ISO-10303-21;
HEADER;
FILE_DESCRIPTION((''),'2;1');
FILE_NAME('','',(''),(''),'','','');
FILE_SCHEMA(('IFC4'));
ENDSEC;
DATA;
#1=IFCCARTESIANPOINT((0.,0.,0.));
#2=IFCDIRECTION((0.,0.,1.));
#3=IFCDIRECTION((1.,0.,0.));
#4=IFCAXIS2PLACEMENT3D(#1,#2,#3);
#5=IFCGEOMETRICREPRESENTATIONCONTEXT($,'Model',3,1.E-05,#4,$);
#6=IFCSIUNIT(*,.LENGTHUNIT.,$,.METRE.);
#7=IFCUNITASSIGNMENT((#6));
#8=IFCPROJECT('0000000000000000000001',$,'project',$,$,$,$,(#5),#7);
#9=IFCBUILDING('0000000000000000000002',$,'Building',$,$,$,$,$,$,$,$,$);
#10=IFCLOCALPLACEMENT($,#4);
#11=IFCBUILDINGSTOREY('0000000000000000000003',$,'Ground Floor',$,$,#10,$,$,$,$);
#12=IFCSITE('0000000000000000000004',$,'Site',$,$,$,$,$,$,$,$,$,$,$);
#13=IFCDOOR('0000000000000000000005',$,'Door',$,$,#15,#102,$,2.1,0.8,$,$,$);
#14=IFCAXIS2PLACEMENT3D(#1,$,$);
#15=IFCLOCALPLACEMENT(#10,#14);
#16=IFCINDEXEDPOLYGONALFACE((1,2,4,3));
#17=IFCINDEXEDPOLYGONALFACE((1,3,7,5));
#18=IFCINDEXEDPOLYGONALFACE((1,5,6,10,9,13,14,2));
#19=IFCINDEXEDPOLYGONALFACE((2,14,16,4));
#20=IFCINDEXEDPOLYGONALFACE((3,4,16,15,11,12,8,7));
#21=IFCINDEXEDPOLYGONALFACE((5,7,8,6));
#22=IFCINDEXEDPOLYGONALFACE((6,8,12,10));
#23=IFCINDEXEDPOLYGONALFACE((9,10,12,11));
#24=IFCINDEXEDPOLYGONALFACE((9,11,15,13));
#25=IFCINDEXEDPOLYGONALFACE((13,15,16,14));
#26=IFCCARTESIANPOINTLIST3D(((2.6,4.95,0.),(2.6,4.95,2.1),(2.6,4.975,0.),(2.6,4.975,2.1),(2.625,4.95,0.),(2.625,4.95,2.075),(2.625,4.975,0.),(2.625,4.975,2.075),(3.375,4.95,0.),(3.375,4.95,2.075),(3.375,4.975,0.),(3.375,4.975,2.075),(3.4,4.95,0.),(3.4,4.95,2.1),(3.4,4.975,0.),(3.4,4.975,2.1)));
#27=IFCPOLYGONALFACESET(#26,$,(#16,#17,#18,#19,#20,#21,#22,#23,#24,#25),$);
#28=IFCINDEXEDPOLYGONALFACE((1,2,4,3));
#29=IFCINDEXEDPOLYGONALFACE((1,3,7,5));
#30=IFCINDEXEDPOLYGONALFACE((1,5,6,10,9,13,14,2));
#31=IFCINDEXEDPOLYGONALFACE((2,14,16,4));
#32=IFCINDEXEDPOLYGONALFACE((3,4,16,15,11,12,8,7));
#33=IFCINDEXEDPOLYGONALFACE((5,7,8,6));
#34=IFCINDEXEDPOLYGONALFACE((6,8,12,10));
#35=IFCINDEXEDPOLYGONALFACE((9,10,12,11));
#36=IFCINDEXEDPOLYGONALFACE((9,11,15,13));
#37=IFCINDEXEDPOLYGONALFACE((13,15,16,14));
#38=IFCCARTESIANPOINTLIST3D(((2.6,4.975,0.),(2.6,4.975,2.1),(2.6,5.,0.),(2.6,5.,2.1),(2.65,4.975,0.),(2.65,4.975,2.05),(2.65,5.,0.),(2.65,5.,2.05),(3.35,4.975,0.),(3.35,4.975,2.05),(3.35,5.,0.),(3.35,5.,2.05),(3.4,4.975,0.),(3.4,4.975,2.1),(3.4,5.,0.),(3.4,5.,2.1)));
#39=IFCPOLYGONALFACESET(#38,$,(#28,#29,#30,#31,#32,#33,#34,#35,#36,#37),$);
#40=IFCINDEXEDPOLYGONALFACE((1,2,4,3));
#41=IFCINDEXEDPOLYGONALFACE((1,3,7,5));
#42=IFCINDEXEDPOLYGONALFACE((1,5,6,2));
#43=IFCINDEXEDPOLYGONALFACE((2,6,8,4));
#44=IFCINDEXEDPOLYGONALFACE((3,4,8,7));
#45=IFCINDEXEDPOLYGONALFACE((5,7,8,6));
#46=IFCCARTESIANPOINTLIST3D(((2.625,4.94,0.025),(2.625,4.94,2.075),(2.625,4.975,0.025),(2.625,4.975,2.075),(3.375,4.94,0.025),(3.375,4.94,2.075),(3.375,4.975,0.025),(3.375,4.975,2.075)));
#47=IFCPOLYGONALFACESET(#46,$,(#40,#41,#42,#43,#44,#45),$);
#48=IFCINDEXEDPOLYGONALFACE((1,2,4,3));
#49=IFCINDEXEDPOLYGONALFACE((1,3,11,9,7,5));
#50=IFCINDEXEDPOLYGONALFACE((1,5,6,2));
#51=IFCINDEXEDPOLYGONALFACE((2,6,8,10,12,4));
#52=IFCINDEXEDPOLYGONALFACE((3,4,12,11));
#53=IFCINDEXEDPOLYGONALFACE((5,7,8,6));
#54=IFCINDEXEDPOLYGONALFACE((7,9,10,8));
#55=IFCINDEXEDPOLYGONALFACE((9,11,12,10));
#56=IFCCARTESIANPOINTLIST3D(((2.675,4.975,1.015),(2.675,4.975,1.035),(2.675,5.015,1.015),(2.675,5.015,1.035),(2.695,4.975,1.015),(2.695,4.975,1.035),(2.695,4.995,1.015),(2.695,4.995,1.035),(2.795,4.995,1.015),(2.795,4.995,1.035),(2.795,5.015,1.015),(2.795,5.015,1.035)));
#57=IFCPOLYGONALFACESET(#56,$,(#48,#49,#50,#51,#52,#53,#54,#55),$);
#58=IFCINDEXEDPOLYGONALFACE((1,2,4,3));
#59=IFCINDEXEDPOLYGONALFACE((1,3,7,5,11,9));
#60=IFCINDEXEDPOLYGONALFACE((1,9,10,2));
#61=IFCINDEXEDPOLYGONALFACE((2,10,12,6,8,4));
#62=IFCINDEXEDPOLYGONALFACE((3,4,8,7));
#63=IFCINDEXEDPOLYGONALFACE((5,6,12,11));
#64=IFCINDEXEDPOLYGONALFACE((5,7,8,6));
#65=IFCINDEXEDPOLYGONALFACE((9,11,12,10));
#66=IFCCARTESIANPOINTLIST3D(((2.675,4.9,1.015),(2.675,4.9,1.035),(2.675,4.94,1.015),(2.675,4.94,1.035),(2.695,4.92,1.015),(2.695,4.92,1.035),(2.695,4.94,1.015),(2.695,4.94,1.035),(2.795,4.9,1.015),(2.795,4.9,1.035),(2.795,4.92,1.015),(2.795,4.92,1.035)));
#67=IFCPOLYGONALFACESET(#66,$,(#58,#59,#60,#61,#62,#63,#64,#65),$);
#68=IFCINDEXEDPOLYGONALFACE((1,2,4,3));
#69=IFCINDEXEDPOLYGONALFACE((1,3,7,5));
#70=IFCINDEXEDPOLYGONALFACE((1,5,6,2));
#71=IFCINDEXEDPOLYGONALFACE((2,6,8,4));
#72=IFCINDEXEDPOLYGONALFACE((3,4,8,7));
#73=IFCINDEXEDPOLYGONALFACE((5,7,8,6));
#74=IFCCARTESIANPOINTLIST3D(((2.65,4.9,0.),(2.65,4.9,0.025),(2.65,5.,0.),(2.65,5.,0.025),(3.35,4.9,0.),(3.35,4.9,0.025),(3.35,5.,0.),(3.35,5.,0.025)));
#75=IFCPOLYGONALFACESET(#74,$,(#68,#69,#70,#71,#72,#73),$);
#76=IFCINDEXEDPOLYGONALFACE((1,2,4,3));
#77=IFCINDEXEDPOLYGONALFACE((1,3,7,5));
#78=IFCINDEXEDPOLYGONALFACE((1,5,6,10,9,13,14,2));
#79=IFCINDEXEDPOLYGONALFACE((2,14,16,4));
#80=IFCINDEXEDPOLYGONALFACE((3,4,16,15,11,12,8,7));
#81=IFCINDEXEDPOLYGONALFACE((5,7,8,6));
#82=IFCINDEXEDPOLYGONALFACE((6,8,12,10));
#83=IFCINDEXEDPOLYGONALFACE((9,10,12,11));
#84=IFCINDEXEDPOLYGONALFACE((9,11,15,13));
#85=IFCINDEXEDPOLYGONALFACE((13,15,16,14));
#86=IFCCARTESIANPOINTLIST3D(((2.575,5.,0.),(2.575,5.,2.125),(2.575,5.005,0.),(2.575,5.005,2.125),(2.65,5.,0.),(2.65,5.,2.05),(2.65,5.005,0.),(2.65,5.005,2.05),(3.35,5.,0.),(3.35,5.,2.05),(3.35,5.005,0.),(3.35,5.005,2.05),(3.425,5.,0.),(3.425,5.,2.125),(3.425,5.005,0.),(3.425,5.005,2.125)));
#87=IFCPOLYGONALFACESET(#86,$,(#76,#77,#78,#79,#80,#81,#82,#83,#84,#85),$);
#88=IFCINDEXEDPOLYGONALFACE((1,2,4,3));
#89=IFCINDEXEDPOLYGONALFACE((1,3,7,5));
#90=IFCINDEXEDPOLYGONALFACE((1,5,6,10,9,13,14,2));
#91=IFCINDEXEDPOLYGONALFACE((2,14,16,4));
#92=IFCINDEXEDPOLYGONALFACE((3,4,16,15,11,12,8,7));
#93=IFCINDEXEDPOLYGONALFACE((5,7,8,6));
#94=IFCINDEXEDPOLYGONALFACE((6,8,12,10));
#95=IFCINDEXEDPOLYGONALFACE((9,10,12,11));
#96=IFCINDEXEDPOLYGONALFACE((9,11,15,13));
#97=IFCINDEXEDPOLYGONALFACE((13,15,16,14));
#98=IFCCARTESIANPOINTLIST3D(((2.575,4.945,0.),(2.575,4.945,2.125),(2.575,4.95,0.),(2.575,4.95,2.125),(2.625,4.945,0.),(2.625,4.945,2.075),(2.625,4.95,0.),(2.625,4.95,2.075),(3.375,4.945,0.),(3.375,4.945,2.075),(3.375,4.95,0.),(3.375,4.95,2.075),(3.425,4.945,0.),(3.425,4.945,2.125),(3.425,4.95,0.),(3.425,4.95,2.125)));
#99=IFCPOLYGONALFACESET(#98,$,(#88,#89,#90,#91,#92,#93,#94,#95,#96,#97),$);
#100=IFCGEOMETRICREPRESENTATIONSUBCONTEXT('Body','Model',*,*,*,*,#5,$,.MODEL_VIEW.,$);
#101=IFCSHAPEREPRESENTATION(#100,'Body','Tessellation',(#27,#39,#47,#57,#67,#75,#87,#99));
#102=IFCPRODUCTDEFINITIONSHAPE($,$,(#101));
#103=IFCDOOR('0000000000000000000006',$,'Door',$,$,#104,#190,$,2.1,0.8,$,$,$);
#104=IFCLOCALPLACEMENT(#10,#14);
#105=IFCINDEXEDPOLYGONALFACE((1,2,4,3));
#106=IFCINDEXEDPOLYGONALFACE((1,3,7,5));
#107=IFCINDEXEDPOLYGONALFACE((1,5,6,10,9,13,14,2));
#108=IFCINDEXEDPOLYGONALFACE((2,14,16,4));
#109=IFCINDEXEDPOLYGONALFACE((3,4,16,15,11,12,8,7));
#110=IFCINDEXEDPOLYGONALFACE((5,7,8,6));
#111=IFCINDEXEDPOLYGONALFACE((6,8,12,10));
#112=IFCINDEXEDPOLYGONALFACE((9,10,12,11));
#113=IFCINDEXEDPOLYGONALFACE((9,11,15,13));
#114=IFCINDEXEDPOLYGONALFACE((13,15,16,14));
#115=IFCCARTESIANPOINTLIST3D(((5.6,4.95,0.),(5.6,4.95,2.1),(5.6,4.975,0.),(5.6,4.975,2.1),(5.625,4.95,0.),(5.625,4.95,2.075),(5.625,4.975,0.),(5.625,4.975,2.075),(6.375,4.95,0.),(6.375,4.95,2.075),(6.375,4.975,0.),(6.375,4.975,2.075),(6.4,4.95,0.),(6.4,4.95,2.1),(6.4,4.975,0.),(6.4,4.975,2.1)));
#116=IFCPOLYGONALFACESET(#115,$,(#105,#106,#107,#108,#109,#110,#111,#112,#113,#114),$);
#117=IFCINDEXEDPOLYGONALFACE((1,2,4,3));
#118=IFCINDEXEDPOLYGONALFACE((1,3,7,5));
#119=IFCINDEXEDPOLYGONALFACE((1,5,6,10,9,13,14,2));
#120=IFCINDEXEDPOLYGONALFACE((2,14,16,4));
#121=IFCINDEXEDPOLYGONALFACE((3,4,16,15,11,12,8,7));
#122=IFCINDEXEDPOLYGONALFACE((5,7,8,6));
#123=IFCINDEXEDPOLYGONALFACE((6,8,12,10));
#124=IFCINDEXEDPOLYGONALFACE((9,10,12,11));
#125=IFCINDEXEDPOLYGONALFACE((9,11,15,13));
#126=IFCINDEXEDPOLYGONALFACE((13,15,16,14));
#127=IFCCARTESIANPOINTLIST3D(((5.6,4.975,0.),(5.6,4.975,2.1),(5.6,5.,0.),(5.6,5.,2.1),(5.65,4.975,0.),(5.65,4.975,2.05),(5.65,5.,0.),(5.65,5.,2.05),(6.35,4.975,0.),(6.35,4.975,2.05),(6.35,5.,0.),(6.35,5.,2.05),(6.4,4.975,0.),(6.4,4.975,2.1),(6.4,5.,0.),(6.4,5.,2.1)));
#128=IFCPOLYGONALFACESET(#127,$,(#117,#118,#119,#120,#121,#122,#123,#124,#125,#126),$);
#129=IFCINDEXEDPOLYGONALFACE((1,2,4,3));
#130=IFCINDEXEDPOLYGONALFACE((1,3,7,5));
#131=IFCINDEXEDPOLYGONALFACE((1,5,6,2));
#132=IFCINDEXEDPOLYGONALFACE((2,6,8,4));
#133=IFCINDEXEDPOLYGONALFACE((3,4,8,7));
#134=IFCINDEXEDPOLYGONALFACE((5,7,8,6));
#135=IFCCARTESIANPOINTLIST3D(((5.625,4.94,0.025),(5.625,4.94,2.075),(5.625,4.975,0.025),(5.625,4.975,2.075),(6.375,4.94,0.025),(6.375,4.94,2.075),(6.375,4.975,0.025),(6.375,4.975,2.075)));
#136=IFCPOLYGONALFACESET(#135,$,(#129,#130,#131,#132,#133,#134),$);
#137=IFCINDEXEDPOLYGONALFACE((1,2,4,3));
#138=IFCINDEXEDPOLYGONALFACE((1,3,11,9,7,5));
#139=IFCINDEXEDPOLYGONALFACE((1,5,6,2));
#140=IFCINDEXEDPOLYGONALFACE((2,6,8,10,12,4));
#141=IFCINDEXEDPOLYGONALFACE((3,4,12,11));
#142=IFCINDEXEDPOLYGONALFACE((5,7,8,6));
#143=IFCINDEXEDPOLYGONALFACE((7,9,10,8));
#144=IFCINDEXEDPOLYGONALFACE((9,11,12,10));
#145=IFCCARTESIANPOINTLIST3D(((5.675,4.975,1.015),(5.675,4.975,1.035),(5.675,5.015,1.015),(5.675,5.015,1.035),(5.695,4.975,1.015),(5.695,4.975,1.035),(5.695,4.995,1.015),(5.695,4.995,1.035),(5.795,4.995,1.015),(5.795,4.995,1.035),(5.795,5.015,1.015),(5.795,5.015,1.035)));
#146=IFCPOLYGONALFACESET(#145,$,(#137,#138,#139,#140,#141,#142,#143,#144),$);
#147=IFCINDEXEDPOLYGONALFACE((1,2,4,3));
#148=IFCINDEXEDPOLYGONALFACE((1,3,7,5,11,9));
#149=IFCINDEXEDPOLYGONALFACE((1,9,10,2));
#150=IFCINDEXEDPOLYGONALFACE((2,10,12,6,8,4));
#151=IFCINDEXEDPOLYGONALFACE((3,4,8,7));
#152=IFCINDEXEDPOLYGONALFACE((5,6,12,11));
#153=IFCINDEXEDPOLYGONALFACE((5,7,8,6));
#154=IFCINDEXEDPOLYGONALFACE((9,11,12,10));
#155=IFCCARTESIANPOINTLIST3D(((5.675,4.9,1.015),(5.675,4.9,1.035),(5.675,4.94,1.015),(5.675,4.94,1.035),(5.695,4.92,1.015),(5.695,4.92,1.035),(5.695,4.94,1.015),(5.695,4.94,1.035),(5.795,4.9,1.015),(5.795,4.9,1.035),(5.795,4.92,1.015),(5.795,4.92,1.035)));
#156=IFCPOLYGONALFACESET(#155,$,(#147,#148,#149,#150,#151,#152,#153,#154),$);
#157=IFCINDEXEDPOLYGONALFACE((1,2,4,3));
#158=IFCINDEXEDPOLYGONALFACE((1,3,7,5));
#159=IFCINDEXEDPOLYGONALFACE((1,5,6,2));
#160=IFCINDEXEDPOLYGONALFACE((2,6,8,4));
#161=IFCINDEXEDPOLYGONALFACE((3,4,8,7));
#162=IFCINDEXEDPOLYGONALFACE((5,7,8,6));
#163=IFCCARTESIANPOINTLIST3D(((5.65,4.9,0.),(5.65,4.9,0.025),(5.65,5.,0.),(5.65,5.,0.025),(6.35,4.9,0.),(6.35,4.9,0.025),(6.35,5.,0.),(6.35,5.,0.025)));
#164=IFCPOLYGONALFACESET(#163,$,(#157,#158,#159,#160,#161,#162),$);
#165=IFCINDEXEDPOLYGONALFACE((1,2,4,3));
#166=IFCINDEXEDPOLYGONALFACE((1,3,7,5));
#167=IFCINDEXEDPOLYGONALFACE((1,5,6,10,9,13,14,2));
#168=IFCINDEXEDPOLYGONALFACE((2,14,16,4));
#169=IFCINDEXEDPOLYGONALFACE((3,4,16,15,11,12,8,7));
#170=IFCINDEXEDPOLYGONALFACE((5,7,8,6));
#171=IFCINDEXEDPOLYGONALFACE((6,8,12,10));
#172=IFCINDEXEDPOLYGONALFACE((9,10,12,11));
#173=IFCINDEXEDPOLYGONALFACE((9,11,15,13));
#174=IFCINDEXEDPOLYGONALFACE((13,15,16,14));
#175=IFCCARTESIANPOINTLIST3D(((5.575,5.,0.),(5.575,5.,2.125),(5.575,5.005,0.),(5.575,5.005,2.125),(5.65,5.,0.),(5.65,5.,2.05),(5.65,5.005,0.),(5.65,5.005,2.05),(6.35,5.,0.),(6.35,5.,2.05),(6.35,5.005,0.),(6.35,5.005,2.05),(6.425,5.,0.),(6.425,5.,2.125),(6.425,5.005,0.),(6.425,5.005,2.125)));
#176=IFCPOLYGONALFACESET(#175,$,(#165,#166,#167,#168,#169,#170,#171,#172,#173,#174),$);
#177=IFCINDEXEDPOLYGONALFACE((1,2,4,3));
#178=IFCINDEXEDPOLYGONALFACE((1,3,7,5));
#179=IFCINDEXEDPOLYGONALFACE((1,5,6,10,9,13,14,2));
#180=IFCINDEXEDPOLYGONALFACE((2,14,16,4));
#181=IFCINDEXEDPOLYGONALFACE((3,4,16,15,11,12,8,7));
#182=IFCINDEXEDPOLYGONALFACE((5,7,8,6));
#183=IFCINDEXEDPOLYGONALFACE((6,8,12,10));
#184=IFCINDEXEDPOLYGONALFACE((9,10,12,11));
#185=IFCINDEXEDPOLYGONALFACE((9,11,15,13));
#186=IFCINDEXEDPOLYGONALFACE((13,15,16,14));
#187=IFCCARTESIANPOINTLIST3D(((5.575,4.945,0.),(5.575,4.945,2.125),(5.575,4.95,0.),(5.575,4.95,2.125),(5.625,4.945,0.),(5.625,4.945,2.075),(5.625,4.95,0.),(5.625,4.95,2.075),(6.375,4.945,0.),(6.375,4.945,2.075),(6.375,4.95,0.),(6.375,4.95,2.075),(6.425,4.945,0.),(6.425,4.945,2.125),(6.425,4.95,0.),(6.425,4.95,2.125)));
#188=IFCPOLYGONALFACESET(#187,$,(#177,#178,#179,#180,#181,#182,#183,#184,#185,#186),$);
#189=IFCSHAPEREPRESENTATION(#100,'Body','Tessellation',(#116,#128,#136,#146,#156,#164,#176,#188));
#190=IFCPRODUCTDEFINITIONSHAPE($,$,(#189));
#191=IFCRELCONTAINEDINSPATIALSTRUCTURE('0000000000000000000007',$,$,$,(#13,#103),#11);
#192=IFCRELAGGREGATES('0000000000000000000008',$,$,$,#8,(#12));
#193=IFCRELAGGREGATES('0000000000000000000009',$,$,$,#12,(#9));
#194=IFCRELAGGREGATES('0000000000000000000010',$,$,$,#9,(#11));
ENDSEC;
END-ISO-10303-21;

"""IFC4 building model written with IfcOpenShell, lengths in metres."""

from ifc_helpers import new_model, si_unit, frame, origin_with_axes, place, context, subcontext, project, spatial, line, indexed_curve, outline, extrude, element, save


model = new_model("IFC4")

# Units and contexts
model_context = context("Model", 3, precision=1e-05, world=origin_with_axes())
body_context = subcontext(model_context, "Body", "Model", "MODEL_VIEW")
ifc_project = project(units=[si_unit("LENGTHUNIT", "METRE")], contexts=[model_context])

# Site, building, storey
site = spatial("IfcSite", under=ifc_project, Name="Site")
building = spatial("IfcBuilding", under=site, Name="Building")
storey_placement = place(None, origin_with_axes())
storey = spatial("IfcBuildingStorey", under=building, at=storey_placement, Name="Ground Floor")

# Doors
door_1_placement = place(storey_placement, frame((3.4, 5.0, 0.0), z_axis=(0.0, 0.0, 1.0), x_axis=(-1.0, 0.0, 0.0)))
element("IfcDoor", 1, at=door_1_placement, inside=storey, Name="Door", OverallHeight=2.1, OverallWidth=0.8, context=body_context, shape_type="SweptSolid", body=[
    extrude(outline(indexed_curve([(0.0, 0.0), (0.0, 2.1), (0.8, 2.1), (0.8, 0.0), (0.775, 0.0), (0.775, 2.075), (0.025, 2.075), (0.025, 0.0)], segments=[line(1, 2, 3, 4, 5, 6, 7, 8, 1)])), frame((0.0, 0.025, 0.0), z_axis=(0.0, -1.0, 0.0), x_axis=(1.0, 0.0, 0.0)), (0.0, 0.0, -1.0), 0.025),
    extrude(outline(indexed_curve([(0.0, 0.0), (0.0, 2.1), (0.8, 2.1), (0.8, 0.0), (0.75, 0.0), (0.75, 2.05), (0.05, 2.05), (0.05, 0.0)], segments=[line(1, 2, 3, 4, 5, 6, 7, 8, 1)])), frame((0.0, 0.0, 0.0), z_axis=(0.0, -1.0, 0.0), x_axis=(1.0, 0.0, 0.0)), (0.0, 0.0, -1.0), 0.025),
    extrude(outline(indexed_curve([(0.0, 0.0), (0.75, 0.0), (0.75, 0.035), (0.0, 0.035)], segments=[line(1, 2, 3, 4, 1)])), frame((0.025, 0.025, 0.025), z_axis=(0.0, 0.0, 1.0), x_axis=(1.0, 0.0, 0.0)), (0.0, 0.0, 1.0), 2.05),
    extrude(outline(indexed_curve([(0.0, 0.0), (0.0, -0.04), (-0.12, -0.04), (-0.12, -0.02), (-0.02, -0.02), (-0.02, 0.0)], segments=[line(1, 2, 3, 4, 5, 6, 1)])), frame((0.725, 0.025, 1.015), z_axis=(0.0, 0.0, 1.0), x_axis=(1.0, 0.0, 0.0)), (0.0, 0.0, 1.0), 0.02),
    extrude(outline(indexed_curve([(0.0, 0.0), (0.0, 0.04), (-0.12, 0.04), (-0.12, 0.02), (-0.02, 0.02), (-0.02, 0.0)], segments=[line(1, 2, 3, 4, 5, 6, 1)])), frame((0.725, 0.06, 1.015), z_axis=(0.0, 0.0, 1.0), x_axis=(1.0, 0.0, 0.0)), (0.0, 0.0, 1.0), 0.02),
    extrude(outline(indexed_curve([(0.0, 0.0), (0.7, 0.0), (0.7, 0.1), (0.0, 0.1)], segments=[line(1, 2, 3, 4, 1)])), frame((0.05, 0.0, 0.0), z_axis=(0.0, 0.0, 1.0), x_axis=(1.0, 0.0, 0.0)), (0.0, 0.0, 1.0), 0.025),
    extrude(outline(indexed_curve([(0.0, 0.0), (0.0, 2.125), (0.85, 2.125), (0.85, 0.0), (0.775, 0.0), (0.775, 2.05), (0.075, 2.05), (0.075, 0.0)], segments=[line(1, 2, 3, 4, 5, 6, 7, 8, 1)])), frame((-0.025, -0.005, 0.0), z_axis=(0.0, -1.0, 0.0), x_axis=(1.0, 0.0, 0.0)), (0.0, 0.0, -1.0), 0.005),
    extrude(outline(indexed_curve([(0.0, 0.0), (0.0, 2.125), (0.85, 2.125), (0.85, 0.0), (0.8, 0.0), (0.8, 2.075), (0.05, 2.075), (0.05, 0.0)], segments=[line(1, 2, 3, 4, 5, 6, 7, 8, 1)])), frame((-0.025, 0.05, 0.0), z_axis=(0.0, -1.0, 0.0), x_axis=(1.0, 0.0, 0.0)), (0.0, 0.0, -1.0), 0.005),
])
door_2_placement = place(storey_placement, frame((6.4, 5.0, 0.0), z_axis=(0.0, 0.0, 1.0), x_axis=(-1.0, 0.0, 0.0)))
element("IfcDoor", 2, at=door_2_placement, inside=storey, Name="Door", OverallHeight=2.1, OverallWidth=0.8, context=body_context, shape_type="SweptSolid", body=[
    extrude(outline(indexed_curve([(0.0, 0.0), (0.0, 2.1), (0.8, 2.1), (0.8, 0.0), (0.775, 0.0), (0.775, 2.075), (0.025, 2.075), (0.025, 0.0)], segments=[line(1, 2, 3, 4, 5, 6, 7, 8, 1)])), frame((0.0, 0.025, 0.0), z_axis=(0.0, -1.0, 0.0), x_axis=(1.0, 0.0, 0.0)), (0.0, 0.0, -1.0), 0.025),
    extrude(outline(indexed_curve([(0.0, 0.0), (0.0, 2.1), (0.8, 2.1), (0.8, 0.0), (0.75, 0.0), (0.75, 2.05), (0.05, 2.05), (0.05, 0.0)], segments=[line(1, 2, 3, 4, 5, 6, 7, 8, 1)])), frame((0.0, 0.0, 0.0), z_axis=(0.0, -1.0, 0.0), x_axis=(1.0, 0.0, 0.0)), (0.0, 0.0, -1.0), 0.025),
    extrude(outline(indexed_curve([(0.0, 0.0), (0.75, 0.0), (0.75, 0.035), (0.0, 0.035)], segments=[line(1, 2, 3, 4, 1)])), frame((0.025, 0.025, 0.025), z_axis=(0.0, 0.0, 1.0), x_axis=(1.0, 0.0, 0.0)), (0.0, 0.0, 1.0), 2.05),
    extrude(outline(indexed_curve([(0.0, 0.0), (0.0, -0.04), (-0.12, -0.04), (-0.12, -0.02), (-0.02, -0.02), (-0.02, 0.0)], segments=[line(1, 2, 3, 4, 5, 6, 1)])), frame((0.725, 0.025, 1.015), z_axis=(0.0, 0.0, 1.0), x_axis=(1.0, 0.0, 0.0)), (0.0, 0.0, 1.0), 0.02),
    extrude(outline(indexed_curve([(0.0, 0.0), (0.0, 0.04), (-0.12, 0.04), (-0.12, 0.02), (-0.02, 0.02), (-0.02, 0.0)], segments=[line(1, 2, 3, 4, 5, 6, 1)])), frame((0.725, 0.06, 1.015), z_axis=(0.0, 0.0, 1.0), x_axis=(1.0, 0.0, 0.0)), (0.0, 0.0, 1.0), 0.02),
    extrude(outline(indexed_curve([(0.0, 0.0), (0.7, 0.0), (0.7, 0.1), (0.0, 0.1)], segments=[line(1, 2, 3, 4, 1)])), frame((0.05, 0.0, 0.0), z_axis=(0.0, 0.0, 1.0), x_axis=(1.0, 0.0, 0.0)), (0.0, 0.0, 1.0), 0.025),
    extrude(outline(indexed_curve([(0.0, 0.0), (0.0, 2.125), (0.85, 2.125), (0.85, 0.0), (0.775, 0.0), (0.775, 2.05), (0.075, 2.05), (0.075, 0.0)], segments=[line(1, 2, 3, 4, 5, 6, 7, 8, 1)])), frame((-0.025, -0.005, 0.0), z_axis=(0.0, -1.0, 0.0), x_axis=(1.0, 0.0, 0.0)), (0.0, 0.0, -1.0), 0.005),
    extrude(outline(indexed_curve([(0.0, 0.0), (0.0, 2.125), (0.85, 2.125), (0.85, 0.0), (0.8, 0.0), (0.8, 2.075), (0.05, 2.075), (0.05, 0.0)], segments=[line(1, 2, 3, 4, 5, 6, 7, 8, 1)])), frame((-0.025, 0.05, 0.0), z_axis=(0.0, -1.0, 0.0), x_axis=(1.0, 0.0, 0.0)), (0.0, 0.0, -1.0), 0.005),
])

save(model, "model.ifc")
